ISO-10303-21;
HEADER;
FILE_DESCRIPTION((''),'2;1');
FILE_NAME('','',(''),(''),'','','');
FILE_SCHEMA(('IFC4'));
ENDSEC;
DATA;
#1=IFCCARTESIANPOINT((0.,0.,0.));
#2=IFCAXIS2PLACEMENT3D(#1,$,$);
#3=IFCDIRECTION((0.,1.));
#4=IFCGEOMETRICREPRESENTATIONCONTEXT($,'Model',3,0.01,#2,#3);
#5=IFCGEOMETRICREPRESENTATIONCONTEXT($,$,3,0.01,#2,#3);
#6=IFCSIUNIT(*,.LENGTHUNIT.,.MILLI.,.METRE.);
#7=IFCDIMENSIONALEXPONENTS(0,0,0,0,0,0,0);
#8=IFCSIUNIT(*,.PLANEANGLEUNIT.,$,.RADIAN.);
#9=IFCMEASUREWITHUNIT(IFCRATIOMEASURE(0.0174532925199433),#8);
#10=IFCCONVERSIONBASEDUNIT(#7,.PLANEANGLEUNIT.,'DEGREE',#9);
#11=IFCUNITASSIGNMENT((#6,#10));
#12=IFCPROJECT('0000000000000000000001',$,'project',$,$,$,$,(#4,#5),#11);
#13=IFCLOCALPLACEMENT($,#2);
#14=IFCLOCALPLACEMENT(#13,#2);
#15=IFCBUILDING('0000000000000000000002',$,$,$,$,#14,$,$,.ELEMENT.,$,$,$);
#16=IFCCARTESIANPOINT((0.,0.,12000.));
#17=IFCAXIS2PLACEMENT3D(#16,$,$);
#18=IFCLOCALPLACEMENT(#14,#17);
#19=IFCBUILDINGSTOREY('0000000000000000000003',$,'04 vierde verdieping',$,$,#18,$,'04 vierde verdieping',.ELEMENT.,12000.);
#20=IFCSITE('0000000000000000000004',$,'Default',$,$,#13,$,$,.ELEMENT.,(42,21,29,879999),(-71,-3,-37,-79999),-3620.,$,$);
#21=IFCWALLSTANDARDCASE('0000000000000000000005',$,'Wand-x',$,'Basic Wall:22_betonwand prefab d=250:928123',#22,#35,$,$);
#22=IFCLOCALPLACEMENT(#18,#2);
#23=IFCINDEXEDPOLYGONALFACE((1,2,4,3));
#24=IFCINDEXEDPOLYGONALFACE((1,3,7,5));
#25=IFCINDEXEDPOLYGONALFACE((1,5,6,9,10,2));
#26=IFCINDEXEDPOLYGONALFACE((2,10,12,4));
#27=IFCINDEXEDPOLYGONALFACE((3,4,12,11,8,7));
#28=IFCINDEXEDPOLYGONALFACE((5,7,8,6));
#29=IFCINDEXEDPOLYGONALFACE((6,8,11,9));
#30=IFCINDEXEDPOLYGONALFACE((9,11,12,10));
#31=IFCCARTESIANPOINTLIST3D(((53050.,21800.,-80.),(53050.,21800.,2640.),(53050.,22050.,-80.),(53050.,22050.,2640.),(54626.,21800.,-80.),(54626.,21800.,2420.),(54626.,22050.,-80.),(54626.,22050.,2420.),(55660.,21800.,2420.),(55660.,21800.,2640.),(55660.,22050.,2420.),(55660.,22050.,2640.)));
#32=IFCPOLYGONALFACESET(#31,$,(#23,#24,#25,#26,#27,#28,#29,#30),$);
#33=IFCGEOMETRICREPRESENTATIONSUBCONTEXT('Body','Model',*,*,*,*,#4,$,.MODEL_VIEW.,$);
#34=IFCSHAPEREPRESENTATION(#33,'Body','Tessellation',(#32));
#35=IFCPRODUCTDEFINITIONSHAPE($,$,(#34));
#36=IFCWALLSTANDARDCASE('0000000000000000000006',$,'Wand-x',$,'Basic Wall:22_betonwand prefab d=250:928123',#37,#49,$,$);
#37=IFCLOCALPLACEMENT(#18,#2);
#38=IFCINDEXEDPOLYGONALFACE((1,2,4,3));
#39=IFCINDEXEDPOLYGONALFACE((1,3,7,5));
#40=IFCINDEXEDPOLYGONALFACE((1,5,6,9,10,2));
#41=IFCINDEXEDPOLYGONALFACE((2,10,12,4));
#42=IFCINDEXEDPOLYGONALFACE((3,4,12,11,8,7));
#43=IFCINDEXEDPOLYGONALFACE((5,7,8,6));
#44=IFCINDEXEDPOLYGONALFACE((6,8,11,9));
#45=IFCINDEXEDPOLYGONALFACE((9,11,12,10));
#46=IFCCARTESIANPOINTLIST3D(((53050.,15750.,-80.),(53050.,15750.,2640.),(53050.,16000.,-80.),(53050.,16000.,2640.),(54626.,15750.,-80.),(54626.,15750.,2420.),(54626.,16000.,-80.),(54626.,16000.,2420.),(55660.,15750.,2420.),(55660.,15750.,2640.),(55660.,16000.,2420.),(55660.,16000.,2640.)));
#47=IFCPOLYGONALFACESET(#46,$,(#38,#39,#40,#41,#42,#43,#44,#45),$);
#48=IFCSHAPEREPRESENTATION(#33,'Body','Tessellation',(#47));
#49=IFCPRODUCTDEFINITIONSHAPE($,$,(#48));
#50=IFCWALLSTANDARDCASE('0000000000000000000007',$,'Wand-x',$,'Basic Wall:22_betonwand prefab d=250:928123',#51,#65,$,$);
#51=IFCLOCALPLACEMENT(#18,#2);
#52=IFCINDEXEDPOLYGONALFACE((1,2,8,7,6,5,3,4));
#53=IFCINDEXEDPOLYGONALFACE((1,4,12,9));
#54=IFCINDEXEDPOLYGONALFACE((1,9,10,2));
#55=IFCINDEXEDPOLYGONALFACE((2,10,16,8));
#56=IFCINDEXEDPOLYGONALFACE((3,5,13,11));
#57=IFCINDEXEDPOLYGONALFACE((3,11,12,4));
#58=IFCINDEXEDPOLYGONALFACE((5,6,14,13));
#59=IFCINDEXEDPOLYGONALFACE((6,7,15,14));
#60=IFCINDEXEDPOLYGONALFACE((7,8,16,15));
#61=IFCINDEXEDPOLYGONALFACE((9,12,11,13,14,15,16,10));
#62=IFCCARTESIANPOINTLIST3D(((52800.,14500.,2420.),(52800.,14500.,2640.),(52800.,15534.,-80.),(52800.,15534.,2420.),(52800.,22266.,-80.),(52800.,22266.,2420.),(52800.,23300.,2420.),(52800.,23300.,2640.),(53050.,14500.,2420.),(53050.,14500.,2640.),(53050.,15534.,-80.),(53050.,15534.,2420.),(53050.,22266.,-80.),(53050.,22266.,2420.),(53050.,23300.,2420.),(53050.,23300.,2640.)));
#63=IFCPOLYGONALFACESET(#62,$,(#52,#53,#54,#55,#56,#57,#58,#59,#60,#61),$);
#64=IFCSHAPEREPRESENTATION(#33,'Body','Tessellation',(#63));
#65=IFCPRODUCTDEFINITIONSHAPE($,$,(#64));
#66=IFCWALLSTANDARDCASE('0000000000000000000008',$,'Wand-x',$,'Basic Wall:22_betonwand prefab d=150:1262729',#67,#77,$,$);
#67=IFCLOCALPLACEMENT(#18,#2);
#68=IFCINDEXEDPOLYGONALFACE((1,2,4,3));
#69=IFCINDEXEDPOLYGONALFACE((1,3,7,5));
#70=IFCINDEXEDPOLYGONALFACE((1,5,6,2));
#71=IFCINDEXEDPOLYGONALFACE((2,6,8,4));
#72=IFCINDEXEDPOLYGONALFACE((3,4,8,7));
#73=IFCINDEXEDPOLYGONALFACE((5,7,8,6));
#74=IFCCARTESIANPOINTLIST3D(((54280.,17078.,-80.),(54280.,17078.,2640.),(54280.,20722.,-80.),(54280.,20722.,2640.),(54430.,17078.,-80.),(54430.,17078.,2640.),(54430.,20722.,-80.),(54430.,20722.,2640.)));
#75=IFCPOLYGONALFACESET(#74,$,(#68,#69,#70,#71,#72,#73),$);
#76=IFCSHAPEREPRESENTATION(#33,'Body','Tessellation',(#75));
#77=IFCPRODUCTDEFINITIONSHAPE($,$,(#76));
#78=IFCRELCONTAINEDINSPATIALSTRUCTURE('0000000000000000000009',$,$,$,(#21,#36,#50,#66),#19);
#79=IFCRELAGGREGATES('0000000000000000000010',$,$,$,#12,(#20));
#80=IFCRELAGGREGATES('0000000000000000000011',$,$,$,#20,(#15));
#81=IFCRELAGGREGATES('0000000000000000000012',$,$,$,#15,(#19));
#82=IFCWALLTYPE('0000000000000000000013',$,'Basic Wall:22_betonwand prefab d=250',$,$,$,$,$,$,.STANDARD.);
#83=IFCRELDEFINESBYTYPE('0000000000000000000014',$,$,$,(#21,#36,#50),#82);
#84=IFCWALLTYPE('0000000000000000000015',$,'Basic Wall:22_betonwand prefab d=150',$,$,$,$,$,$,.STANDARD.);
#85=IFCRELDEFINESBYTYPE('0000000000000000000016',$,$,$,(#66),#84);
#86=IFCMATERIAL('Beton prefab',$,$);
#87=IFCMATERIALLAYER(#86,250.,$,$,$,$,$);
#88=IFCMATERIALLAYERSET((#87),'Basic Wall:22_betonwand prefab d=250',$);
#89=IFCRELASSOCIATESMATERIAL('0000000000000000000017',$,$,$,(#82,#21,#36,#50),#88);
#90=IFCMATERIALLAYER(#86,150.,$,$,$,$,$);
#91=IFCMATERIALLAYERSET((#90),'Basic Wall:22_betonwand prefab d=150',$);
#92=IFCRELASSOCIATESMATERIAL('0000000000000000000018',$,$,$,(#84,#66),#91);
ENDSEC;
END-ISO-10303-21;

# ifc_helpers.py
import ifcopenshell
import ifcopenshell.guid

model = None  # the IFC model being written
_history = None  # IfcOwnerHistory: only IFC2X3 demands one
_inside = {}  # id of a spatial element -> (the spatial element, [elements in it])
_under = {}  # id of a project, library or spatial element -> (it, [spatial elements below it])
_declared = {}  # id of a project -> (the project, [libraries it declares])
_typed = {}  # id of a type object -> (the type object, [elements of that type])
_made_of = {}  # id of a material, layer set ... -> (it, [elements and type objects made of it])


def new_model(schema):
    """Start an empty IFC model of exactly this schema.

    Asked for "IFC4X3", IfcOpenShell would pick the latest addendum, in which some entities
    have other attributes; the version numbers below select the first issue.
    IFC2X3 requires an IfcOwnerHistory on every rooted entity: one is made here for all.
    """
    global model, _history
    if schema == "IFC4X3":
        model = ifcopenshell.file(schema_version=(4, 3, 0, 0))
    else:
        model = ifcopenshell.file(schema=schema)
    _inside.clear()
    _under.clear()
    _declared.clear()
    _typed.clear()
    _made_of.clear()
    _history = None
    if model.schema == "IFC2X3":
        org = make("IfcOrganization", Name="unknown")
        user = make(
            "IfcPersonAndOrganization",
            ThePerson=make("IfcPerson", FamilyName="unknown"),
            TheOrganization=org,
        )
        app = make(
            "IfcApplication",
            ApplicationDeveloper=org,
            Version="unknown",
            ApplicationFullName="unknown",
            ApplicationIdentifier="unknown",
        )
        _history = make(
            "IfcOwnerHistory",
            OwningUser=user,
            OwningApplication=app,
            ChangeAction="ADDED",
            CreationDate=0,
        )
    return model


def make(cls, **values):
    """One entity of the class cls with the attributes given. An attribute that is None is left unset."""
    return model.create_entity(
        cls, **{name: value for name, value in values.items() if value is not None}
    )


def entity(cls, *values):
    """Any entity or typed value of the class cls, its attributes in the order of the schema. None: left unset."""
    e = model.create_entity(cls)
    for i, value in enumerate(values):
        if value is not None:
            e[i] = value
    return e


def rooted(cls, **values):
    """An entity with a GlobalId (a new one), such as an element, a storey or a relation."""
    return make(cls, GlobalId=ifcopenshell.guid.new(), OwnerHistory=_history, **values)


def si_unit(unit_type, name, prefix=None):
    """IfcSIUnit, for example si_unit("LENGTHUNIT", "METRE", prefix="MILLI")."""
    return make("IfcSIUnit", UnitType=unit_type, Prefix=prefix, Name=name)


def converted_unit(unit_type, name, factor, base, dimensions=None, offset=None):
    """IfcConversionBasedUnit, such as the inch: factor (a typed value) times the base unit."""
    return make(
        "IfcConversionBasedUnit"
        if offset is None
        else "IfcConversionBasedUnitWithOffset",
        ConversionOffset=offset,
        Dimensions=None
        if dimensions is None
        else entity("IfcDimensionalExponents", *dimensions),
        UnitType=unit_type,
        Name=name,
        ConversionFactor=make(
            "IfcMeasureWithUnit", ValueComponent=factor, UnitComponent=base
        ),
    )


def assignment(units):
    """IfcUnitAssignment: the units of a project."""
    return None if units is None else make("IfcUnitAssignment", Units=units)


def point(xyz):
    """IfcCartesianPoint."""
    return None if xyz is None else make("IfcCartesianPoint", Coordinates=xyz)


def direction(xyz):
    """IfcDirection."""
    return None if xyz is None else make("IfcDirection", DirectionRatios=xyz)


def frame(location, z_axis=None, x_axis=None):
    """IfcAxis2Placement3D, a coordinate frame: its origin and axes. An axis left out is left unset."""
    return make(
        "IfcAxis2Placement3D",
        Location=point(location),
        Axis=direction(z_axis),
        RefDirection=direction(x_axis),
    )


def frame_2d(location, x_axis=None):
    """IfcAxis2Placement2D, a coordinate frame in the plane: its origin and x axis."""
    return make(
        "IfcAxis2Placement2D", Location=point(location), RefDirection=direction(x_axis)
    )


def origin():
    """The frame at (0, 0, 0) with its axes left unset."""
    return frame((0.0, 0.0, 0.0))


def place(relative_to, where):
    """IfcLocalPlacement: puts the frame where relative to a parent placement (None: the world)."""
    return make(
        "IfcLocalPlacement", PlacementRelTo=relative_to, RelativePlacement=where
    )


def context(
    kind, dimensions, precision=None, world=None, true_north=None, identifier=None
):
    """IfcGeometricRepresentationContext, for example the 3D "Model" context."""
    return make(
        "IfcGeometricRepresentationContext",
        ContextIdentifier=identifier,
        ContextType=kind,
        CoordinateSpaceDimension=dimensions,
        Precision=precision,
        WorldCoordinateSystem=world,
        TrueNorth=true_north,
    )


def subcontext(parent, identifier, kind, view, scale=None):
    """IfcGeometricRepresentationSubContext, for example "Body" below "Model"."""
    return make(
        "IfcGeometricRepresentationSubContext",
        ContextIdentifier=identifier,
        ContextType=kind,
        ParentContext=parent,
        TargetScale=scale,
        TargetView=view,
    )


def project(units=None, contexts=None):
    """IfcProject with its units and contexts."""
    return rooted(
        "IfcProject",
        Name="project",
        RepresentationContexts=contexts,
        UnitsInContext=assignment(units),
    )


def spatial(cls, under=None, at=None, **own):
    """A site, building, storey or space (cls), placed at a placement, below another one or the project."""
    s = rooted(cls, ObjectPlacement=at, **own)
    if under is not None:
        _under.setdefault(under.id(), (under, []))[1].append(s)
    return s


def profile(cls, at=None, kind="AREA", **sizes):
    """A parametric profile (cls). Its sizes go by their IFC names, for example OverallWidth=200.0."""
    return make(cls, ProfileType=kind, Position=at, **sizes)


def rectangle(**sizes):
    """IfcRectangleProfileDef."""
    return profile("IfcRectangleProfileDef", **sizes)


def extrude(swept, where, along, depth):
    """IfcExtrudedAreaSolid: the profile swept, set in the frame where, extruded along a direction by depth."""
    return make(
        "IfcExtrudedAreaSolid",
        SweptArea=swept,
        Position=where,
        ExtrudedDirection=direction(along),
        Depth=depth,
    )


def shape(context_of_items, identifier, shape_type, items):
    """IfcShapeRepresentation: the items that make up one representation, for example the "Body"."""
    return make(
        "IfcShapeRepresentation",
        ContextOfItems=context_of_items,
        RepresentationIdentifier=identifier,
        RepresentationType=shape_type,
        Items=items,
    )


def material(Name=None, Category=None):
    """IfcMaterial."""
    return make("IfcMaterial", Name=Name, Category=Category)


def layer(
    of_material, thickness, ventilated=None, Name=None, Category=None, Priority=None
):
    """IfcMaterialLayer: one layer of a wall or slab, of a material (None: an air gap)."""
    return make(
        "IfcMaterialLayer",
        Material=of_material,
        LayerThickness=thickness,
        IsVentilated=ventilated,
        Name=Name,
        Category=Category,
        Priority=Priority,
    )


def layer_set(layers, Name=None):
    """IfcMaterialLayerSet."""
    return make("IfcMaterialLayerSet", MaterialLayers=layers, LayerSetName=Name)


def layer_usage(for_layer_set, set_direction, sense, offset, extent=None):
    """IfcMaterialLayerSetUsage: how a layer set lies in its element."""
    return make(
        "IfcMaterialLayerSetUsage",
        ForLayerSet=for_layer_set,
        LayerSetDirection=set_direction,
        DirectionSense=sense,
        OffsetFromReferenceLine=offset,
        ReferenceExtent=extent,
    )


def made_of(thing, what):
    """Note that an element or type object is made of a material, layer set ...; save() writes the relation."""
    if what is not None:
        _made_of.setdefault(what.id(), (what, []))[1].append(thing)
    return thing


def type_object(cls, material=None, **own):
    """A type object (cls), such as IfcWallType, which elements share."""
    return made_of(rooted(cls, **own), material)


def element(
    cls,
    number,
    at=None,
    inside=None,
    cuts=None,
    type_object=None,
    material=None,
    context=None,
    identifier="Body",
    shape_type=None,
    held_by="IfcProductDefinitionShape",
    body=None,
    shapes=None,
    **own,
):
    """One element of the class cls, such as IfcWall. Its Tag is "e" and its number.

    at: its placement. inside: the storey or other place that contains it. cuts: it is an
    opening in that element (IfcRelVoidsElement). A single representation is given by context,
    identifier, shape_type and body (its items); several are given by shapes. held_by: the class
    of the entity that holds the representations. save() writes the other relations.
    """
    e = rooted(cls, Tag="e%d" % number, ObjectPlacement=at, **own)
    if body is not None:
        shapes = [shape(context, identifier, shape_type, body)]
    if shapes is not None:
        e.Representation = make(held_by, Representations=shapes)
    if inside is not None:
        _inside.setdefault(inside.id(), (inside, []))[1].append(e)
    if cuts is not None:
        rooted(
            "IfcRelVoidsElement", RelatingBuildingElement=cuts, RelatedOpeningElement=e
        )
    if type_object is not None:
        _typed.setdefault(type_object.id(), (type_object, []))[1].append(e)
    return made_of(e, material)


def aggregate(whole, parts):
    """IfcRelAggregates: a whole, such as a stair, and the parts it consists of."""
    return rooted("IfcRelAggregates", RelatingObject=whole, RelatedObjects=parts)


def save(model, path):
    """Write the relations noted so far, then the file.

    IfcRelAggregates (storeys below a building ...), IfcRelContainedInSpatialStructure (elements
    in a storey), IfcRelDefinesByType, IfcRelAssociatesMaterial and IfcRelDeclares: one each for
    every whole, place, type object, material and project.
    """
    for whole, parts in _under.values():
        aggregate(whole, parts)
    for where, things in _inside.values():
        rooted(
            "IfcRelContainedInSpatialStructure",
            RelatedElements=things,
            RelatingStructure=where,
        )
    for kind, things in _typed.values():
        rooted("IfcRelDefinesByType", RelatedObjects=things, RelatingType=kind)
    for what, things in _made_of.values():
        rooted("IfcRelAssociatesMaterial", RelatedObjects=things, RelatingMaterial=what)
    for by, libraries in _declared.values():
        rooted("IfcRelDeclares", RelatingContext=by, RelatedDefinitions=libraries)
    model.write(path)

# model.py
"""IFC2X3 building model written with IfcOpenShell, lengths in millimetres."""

from ifc_helpers import new_model, entity, si_unit, converted_unit, direction, frame, frame_2d, origin, place, context, subcontext, project, spatial, rectangle, extrude, material, layer, layer_set, layer_usage, type_object, element, save


model = new_model("IFC2X3")

# Units and contexts
model_context = context("Model", 3, precision=0.01, world=origin(), true_north=direction((0.0, 1.0)))
context_of_model = context(None, 3, precision=0.01, world=origin(), true_north=direction((0.0, 1.0)))
body_context = subcontext(model_context, "Body", "Model", "MODEL_VIEW")
ifc_project = project(units=[si_unit("LENGTHUNIT", "METRE", prefix="MILLI"), converted_unit("PLANEANGLEUNIT", "DEGREE", entity("IfcRatioMeasure", 0.0174532925199433), si_unit("PLANEANGLEUNIT", "RADIAN"), dimensions=[0, 0, 0, 0, 0, 0, 0])], contexts=[model_context, context_of_model])

# Site, building, storey
site_placement = place(None, origin())
site = spatial("IfcSite", under=ifc_project, at=site_placement, Name="Default", CompositionType="ELEMENT", RefLatitude=(42, 21, 29, 879999), RefLongitude=(-71, -3, -37, -79999), RefElevation=-3620.0)
building_placement = place(site_placement, origin())
building = spatial("IfcBuilding", under=site, at=building_placement, CompositionType="ELEMENT")
storey_placement = place(building_placement, frame((0.0, 0.0, 12000.0)))
storey = spatial("IfcBuildingStorey", under=building, at=storey_placement, Name="04 vierde verdieping", LongName="04 vierde verdieping", CompositionType="ELEMENT", Elevation=12000.0)

# Shared definitions
ifc_material_1 = material(Name="Beton prefab")

# Walls, openings
ifc_layer_1 = layer(ifc_material_1, 250.0)
ifc_layer_set_1 = layer_set([ifc_layer_1], Name="Basic Wall:22_betonwand prefab d=250")
ifc_layer_usage_1 = layer_usage(ifc_layer_set_1, "AXIS2", "NEGATIVE", 125.0)
wall_type_1 = type_object("IfcWallType", Name="Basic Wall:22_betonwand prefab d=250", PredefinedType="STANDARD", material=ifc_layer_set_1)
wall_1_placement = place(storey_placement, frame((53050.0, 21925.0, -80.0)))
wall_1 = element("IfcWallStandardCase", 1, at=wall_1_placement, inside=storey, type_object=wall_type_1, material=ifc_layer_usage_1, Name="Wand-x", ObjectType="Basic Wall:22_betonwand prefab d=250:928123", context=body_context, shape_type="SweptSolid", body=[
    extrude(rectangle(XDim=2610.0, YDim=250.0, at=frame_2d((1305.0, 0.0), x_axis=(-1.0, 0.0))), origin(), (0.0, 0.0, 1.0), 2720.0),
])
opening_1_placement = place(wall_1_placement, frame((-53050.0, -21925.0, 80.0)))
element("IfcOpeningElement", 2, at=opening_1_placement, cuts=wall_1, ObjectType="Opening", context=body_context, shape_type="SweptSolid", body=[
    extrude(rectangle(XDim=2500.0, YDim=1034.0, at=frame_2d((0.0, 0.0), x_axis=(1.0, 0.0))), frame((55143.0, 21525.0, 1170.0), z_axis=(0.0, 1.0, 0.0), x_axis=(0.0, 0.0, -1.0)), (0.0, 0.0, 1.0), 800.0),
])
ifc_layer_usage_2 = layer_usage(ifc_layer_set_1, "AXIS2", "POSITIVE", -125.0)
wall_2_placement = place(storey_placement, frame((53050.0, 15875.0, -80.0)))
wall_2 = element("IfcWallStandardCase", 3, at=wall_2_placement, inside=storey, type_object=wall_type_1, material=ifc_layer_usage_2, Name="Wand-x", ObjectType="Basic Wall:22_betonwand prefab d=250:928123", context=body_context, shape_type="SweptSolid", body=[
    extrude(rectangle(XDim=2610.0, YDim=250.0, at=frame_2d((1305.0, 0.0), x_axis=(-1.0, 0.0))), origin(), (0.0, 0.0, 1.0), 2720.0),
])
opening_2_placement = place(wall_2_placement, frame((-53050.0, -15875.0, 80.0)))
element("IfcOpeningElement", 4, at=opening_2_placement, cuts=wall_2, ObjectType="Opening", context=body_context, shape_type="SweptSolid", body=[
    extrude(rectangle(XDim=2500.0, YDim=1034.0, at=frame_2d((0.0, 0.0), x_axis=(1.0, 0.0))), frame((55143.0, 15475.0, 1170.0), z_axis=(0.0, 1.0, 0.0), x_axis=(0.0, 0.0, -1.0)), (0.0, 0.0, 1.0), 800.0),
])

# Wall, openings
ifc_layer_usage_3 = layer_usage(ifc_layer_set_1, "AXIS2", "NEGATIVE", 125.0)
wall_3_placement = place(storey_placement, frame((52925.0, 14500.0, -80.0), z_axis=(0.0, 0.0, 1.0), x_axis=(0.0, 1.0, 0.0)))
wall_3 = element("IfcWallStandardCase", 5, at=wall_3_placement, inside=storey, type_object=wall_type_1, material=ifc_layer_usage_3, Name="Wand-x", ObjectType="Basic Wall:22_betonwand prefab d=250:928123", context=body_context, shape_type="SweptSolid", body=[
    extrude(rectangle(XDim=8800.0, YDim=250.0, at=frame_2d((4400.0, 0.0), x_axis=(-1.0, 0.0))), origin(), (0.0, 0.0, 1.0), 2720.0),
])
opening_3_placement = place(wall_3_placement, frame((-14500.0, 52925.0, 80.0), z_axis=(0.0, 0.0, 1.0), x_axis=(0.0, -1.0, 0.0)))
element("IfcOpeningElement", 6, at=opening_3_placement, cuts=wall_3, ObjectType="Opening", context=body_context, shape_type="SweptSolid", body=[
    extrude(rectangle(XDim=2500.0, YDim=1034.0, at=frame_2d((0.0, 0.0), x_axis=(1.0, 0.0))), frame((53325.0, 15017.0, 1170.0), z_axis=(-1.0, 0.0, 0.0), x_axis=(0.0, 0.0, -1.0)), (0.0, 0.0, 1.0), 800.0),
])
opening_4_placement = place(wall_3_placement, frame((-14500.0, 52925.0, 80.0), z_axis=(0.0, 0.0, 1.0), x_axis=(0.0, -1.0, 0.0)))
element("IfcOpeningElement", 7, at=opening_4_placement, cuts=wall_3, ObjectType="Opening", context=body_context, shape_type="SweptSolid", body=[
    extrude(rectangle(XDim=2500.0, YDim=1034.0, at=frame_2d((0.0, 0.0), x_axis=(0.0, 1.0))), frame((53325.0, 22783.0, 1170.0), z_axis=(-1.0, 0.0, 0.0), x_axis=(0.0, 1.0, 0.0)), (0.0, 0.0, 1.0), 800.0),
])

# Wall
ifc_layer_2 = layer(ifc_material_1, 150.0)
ifc_layer_set_2 = layer_set([ifc_layer_2], Name="Basic Wall:22_betonwand prefab d=150")
ifc_layer_usage_4 = layer_usage(ifc_layer_set_2, "AXIS2", "NEGATIVE", 75.0)
wall_type_2 = type_object("IfcWallType", Name="Basic Wall:22_betonwand prefab d=150", PredefinedType="STANDARD", material=ifc_layer_set_2)
wall_4_placement = place(storey_placement, frame((54355.0, 17078.0, -80.0), z_axis=(0.0, 0.0, 1.0), x_axis=(0.0, 1.0, 0.0)))
element("IfcWallStandardCase", 8, at=wall_4_placement, inside=storey, type_object=wall_type_2, material=ifc_layer_usage_4, Name="Wand-x", ObjectType="Basic Wall:22_betonwand prefab d=150:1262729", context=body_context, shape_type="SweptSolid", body=[
    extrude(rectangle(XDim=3644.0, YDim=150.0, at=frame_2d((1822.0, 0.0), x_axis=(-1.0, 0.0))), origin(), (0.0, 0.0, 1.0), 2720.0),
])

save(model, "model.ifc")
